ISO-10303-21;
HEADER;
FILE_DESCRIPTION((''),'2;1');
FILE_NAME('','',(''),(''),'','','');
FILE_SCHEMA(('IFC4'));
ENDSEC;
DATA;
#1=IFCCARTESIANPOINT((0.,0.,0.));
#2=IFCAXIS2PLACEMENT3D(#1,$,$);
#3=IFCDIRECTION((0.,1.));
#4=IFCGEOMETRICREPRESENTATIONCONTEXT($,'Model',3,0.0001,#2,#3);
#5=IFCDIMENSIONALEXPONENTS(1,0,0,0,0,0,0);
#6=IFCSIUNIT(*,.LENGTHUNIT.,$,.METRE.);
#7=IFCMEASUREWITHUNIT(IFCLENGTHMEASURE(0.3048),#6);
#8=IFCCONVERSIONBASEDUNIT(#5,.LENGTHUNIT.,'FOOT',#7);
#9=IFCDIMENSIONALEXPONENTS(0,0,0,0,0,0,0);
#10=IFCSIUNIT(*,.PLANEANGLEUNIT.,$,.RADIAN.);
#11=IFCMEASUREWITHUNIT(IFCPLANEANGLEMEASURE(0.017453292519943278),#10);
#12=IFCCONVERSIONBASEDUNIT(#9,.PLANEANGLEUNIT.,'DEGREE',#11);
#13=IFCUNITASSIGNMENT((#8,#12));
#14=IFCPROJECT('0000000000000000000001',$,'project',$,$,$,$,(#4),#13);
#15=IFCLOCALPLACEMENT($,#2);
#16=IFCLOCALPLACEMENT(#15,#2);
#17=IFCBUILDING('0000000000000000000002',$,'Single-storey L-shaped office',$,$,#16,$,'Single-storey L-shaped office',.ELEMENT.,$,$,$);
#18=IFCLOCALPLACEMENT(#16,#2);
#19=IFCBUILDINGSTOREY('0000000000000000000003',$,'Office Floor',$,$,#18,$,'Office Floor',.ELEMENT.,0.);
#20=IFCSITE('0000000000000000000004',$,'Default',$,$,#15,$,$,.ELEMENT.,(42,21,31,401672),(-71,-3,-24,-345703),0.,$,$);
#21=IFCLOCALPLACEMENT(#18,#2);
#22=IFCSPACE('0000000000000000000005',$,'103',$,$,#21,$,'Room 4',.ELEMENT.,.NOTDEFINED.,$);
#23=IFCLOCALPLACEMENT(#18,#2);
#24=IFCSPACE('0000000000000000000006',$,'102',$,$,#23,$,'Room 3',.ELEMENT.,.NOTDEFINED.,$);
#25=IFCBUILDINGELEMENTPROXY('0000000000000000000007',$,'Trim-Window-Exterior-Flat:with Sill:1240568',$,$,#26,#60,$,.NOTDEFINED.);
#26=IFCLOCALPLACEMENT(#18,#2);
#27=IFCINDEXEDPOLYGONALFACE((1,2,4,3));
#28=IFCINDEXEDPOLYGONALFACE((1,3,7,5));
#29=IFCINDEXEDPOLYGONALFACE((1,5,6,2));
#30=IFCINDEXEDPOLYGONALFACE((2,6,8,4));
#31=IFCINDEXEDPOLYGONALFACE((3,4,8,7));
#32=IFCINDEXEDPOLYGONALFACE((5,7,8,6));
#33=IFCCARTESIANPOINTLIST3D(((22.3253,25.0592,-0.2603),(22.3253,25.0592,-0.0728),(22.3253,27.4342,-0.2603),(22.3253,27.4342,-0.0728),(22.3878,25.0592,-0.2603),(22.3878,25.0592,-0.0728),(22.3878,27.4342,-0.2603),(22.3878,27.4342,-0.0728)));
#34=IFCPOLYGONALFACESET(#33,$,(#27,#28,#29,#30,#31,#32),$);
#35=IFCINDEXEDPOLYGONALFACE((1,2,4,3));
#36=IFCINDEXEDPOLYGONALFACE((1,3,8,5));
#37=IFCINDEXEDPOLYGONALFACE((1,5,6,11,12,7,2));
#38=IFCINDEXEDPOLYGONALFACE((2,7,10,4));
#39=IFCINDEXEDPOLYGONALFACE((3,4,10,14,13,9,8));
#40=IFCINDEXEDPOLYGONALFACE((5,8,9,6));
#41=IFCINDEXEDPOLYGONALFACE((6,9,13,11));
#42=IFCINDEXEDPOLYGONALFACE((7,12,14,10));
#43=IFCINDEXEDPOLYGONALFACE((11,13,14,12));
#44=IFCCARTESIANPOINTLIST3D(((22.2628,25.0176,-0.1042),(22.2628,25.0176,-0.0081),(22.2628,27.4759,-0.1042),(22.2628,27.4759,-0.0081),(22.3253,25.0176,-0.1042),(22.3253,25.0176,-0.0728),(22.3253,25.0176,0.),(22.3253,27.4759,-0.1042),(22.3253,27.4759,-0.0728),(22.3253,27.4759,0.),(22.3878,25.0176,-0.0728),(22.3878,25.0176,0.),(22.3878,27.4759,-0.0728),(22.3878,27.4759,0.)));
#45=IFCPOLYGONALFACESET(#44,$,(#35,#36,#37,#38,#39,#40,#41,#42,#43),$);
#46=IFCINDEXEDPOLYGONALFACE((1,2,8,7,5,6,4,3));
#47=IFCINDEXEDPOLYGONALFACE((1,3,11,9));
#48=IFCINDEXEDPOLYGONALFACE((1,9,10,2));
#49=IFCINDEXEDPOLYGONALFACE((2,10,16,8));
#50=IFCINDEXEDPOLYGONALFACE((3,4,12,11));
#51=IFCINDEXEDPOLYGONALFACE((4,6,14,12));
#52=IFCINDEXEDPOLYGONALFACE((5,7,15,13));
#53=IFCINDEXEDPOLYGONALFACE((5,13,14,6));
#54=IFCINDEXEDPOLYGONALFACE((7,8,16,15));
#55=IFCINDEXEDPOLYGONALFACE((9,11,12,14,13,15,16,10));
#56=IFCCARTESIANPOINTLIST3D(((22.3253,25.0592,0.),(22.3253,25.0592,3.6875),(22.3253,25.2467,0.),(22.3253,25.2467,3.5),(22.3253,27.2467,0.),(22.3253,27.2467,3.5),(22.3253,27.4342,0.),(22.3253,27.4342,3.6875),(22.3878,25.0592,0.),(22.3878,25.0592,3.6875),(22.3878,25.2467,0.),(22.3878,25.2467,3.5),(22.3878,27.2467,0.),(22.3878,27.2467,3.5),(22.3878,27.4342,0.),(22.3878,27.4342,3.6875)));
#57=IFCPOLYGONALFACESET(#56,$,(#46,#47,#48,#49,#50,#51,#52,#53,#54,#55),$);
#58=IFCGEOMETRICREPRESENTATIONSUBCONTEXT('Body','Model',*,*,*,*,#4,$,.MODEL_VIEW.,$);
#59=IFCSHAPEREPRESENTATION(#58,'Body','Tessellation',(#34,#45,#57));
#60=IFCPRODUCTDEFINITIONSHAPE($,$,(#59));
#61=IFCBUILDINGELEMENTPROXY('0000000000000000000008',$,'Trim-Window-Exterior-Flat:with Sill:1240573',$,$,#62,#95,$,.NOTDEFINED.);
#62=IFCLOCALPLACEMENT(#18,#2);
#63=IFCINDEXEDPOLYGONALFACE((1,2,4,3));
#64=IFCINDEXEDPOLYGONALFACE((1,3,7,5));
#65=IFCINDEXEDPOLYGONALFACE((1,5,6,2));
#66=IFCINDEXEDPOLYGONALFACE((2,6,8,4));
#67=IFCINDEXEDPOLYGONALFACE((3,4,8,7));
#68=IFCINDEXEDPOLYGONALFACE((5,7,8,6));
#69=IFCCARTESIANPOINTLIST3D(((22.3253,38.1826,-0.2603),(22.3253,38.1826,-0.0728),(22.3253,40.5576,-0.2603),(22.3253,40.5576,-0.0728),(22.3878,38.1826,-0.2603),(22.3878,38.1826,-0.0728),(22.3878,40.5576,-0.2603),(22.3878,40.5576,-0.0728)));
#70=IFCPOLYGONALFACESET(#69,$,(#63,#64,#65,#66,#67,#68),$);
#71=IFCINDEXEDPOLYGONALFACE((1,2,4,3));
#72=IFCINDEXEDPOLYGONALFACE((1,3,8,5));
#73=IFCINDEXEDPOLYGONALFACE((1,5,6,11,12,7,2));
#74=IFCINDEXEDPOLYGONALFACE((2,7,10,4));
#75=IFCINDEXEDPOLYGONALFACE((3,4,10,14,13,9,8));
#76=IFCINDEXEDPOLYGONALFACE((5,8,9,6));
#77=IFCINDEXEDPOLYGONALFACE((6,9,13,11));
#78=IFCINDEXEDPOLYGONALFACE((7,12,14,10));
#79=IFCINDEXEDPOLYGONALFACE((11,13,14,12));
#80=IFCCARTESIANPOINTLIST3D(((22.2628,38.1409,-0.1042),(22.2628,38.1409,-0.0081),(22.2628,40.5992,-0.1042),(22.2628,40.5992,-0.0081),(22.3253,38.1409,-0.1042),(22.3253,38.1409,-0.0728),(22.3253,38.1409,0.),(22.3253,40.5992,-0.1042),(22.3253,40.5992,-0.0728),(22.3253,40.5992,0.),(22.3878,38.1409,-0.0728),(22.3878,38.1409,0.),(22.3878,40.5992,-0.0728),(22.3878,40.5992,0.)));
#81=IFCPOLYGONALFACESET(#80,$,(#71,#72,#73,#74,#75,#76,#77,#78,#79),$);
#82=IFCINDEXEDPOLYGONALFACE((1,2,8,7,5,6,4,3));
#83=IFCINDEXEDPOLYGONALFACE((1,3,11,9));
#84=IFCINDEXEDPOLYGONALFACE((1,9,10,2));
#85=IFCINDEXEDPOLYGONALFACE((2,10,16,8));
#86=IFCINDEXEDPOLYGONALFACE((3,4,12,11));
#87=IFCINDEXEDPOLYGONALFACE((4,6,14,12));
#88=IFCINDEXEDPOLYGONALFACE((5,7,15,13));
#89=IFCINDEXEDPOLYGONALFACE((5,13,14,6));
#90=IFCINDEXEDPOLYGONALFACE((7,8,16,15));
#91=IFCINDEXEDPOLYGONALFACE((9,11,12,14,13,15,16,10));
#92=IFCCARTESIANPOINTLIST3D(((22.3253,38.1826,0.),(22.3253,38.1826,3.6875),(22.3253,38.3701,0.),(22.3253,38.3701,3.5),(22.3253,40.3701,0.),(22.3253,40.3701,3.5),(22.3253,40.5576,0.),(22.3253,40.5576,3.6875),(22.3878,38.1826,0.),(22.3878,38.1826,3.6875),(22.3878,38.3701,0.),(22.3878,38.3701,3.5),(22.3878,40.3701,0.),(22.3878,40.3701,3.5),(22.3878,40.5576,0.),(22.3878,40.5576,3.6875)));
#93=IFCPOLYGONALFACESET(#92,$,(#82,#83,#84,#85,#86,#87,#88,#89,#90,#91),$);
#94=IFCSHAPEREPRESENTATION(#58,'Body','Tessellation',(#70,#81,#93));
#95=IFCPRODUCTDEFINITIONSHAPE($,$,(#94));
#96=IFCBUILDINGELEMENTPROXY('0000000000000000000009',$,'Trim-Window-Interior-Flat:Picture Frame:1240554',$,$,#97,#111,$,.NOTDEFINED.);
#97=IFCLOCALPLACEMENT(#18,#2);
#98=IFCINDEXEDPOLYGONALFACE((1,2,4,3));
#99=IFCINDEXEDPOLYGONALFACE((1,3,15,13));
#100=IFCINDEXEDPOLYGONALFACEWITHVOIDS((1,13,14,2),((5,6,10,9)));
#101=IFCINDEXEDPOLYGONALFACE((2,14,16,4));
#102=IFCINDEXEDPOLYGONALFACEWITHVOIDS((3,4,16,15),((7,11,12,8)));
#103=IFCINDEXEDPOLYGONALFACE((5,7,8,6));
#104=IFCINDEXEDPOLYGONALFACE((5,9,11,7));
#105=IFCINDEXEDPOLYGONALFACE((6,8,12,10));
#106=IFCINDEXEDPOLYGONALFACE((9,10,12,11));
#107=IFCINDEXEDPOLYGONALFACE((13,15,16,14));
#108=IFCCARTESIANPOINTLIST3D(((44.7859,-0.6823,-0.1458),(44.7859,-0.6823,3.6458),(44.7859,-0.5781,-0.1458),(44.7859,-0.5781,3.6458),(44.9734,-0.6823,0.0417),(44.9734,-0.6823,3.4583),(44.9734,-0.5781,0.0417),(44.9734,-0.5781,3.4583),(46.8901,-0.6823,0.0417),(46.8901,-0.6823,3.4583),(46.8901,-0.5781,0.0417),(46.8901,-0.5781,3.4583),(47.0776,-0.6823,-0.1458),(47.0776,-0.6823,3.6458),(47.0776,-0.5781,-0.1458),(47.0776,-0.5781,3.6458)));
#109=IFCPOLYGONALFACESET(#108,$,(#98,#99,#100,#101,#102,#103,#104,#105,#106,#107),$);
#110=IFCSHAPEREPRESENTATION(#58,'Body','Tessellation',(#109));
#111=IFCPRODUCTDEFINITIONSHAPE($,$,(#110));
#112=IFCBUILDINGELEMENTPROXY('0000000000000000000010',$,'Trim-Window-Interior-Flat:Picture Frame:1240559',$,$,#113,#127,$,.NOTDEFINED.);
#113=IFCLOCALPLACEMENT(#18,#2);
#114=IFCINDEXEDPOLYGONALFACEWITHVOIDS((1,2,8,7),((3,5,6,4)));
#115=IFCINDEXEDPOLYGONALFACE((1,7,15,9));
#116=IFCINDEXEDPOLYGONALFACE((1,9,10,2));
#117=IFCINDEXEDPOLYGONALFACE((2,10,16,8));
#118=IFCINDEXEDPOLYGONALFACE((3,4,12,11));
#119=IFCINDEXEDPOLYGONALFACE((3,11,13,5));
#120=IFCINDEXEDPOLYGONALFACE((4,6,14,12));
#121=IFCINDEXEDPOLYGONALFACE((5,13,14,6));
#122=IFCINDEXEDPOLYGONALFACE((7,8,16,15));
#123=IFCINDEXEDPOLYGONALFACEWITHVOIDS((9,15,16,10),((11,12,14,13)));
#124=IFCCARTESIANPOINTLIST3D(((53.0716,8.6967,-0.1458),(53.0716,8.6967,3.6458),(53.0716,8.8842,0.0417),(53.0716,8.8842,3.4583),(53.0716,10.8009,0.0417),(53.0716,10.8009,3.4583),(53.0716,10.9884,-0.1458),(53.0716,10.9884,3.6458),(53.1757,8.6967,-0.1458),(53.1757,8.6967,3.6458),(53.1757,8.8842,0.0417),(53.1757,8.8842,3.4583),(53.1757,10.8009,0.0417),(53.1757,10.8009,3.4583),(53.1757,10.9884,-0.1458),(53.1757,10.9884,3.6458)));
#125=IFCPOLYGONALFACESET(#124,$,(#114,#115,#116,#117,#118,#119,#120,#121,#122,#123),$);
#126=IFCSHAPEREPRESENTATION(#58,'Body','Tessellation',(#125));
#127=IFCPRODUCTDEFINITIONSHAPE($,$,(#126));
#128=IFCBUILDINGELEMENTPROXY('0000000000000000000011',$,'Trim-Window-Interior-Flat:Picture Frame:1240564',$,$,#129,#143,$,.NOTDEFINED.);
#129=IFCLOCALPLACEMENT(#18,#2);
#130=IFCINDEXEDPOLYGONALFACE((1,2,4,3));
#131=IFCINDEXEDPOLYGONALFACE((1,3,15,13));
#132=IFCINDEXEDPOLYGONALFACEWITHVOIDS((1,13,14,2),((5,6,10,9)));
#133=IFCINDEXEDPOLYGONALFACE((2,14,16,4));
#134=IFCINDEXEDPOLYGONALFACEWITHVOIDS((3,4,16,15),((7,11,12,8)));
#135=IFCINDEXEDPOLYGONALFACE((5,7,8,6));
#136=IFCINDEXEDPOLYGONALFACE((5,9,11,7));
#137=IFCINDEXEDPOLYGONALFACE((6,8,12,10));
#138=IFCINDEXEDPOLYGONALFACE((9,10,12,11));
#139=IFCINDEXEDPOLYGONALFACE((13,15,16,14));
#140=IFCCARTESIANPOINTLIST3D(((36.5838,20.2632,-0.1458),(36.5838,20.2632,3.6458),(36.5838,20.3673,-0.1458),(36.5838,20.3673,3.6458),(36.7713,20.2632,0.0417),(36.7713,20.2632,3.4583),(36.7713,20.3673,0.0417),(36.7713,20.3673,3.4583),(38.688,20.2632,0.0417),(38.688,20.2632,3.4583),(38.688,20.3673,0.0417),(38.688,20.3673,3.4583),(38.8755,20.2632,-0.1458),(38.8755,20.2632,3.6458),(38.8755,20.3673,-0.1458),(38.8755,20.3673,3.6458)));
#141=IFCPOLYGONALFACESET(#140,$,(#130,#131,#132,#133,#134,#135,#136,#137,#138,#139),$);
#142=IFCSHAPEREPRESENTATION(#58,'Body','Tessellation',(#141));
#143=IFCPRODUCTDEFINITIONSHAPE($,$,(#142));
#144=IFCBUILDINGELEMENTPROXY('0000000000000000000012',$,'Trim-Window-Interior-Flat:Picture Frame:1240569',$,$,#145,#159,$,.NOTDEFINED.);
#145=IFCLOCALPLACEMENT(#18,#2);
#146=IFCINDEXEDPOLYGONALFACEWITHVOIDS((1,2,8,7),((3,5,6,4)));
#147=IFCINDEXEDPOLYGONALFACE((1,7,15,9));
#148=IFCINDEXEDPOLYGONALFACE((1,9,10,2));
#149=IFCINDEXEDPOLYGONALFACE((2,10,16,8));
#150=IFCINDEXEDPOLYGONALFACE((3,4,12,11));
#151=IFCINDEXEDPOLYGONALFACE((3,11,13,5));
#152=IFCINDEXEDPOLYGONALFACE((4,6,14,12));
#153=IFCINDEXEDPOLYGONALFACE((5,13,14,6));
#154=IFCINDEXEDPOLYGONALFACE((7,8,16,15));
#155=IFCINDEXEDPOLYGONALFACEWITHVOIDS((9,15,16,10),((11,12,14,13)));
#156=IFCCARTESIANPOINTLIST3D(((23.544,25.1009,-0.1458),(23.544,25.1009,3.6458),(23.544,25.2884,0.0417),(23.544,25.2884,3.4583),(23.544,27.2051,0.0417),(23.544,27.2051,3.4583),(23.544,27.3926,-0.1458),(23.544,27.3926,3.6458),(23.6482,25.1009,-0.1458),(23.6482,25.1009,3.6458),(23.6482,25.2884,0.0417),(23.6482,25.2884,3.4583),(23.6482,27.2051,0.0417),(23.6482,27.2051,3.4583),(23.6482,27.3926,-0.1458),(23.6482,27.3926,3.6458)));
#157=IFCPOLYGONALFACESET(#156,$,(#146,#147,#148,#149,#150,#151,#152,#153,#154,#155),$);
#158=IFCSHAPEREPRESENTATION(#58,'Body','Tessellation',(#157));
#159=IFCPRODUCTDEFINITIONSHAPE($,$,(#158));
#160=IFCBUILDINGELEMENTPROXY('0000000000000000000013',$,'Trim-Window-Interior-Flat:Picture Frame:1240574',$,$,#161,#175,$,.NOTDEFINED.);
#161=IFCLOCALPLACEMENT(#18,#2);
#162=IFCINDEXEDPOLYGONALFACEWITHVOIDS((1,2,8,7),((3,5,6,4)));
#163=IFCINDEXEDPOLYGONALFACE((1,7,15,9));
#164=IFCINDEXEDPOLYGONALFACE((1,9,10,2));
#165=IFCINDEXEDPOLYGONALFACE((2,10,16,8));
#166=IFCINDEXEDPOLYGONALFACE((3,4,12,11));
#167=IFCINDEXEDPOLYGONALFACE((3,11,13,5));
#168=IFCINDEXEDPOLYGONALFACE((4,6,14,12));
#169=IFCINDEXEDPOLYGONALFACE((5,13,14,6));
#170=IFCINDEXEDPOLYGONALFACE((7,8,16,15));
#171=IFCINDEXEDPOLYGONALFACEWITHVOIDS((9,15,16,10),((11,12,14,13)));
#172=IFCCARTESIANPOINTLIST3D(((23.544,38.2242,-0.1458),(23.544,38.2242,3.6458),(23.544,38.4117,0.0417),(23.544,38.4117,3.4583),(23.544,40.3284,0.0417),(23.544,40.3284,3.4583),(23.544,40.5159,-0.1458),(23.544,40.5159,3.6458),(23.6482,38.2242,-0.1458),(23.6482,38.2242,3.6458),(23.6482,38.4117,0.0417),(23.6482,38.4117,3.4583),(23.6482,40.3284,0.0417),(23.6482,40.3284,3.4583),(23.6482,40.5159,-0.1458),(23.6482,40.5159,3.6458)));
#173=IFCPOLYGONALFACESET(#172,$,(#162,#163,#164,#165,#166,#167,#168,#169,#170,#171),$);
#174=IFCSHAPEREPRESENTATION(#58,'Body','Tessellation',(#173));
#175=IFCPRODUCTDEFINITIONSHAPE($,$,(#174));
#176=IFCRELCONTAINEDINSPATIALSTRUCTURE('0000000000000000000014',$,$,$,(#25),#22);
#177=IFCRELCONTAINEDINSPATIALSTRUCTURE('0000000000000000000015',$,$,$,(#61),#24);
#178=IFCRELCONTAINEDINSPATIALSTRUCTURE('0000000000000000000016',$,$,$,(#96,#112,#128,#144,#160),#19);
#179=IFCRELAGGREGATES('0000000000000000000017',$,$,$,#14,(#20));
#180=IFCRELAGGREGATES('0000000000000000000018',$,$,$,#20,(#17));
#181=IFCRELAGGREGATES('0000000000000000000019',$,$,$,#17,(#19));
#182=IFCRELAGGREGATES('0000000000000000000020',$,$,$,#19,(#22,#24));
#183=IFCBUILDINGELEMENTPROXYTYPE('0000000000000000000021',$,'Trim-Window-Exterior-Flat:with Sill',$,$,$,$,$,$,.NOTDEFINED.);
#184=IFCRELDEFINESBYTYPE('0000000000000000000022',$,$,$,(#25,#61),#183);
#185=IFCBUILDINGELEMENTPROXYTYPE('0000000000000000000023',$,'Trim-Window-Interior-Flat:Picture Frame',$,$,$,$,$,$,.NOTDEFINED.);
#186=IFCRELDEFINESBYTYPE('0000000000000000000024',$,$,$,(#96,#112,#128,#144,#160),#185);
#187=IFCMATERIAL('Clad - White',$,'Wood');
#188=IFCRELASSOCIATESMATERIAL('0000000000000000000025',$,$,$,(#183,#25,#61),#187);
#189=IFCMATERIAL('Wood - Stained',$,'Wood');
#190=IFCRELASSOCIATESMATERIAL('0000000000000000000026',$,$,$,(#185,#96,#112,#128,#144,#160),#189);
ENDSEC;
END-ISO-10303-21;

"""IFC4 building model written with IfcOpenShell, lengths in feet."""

from ifc_helpers import new_model, entity, si_unit, converted_unit, direction, frame, origin, place, context, subcontext, project, spatial, indexed_curve, outline, extrude, source, transform, mapped, material, type_object, type_shapes, element, save


model = new_model("IFC4")

# Units and contexts
model_context = context("Model", 3, precision=0.0001, world=origin(), true_north=direction((0.0, 1.0)))
body_context = subcontext(model_context, "Body", "Model", "MODEL_VIEW")
ifc_project = project(units=[converted_unit("LENGTHUNIT", "FOOT", entity("IfcLengthMeasure", 0.3048), si_unit("LENGTHUNIT", "METRE"), dimensions=[1, 0, 0, 0, 0, 0, 0]), converted_unit("PLANEANGLEUNIT", "DEGREE", entity("IfcPlaneAngleMeasure", 0.017453292519943278), si_unit("PLANEANGLEUNIT", "RADIAN"), dimensions=[0, 0, 0, 0, 0, 0, 0])], contexts=[model_context])

# Site, building, storey
site_placement = place(None, origin())
site = spatial("IfcSite", under=ifc_project, at=site_placement, Name="Default", CompositionType="ELEMENT", RefLatitude=(42, 21, 31, 401672), RefLongitude=(-71, -3, -24, -345703), RefElevation=0.0)
building_placement = place(site_placement, origin())
building = spatial("IfcBuilding", under=site, at=building_placement, Name="Single-storey L-shaped office", LongName="Single-storey L-shaped office", CompositionType="ELEMENT")
storey_placement = place(building_placement, origin())
storey = spatial("IfcBuildingStorey", under=building, at=storey_placement, Name="Office Floor", LongName="Office Floor", CompositionType="ELEMENT", Elevation=0.0)

# Shared definitions
ifc_material_1 = material(Name="Wood - Stained", Category="Wood")

# Shared definitions
ifc_material_2 = material(Name="Clad - White", Category="Wood")

# Shared definitions
building_element_proxy_type_1 = type_object("IfcBuildingElementProxyType", Name="Trim-Window-Exterior-Flat:with Sill", PredefinedType="NOTDEFINED", material=ifc_material_2)
shared_shape_1 = source(origin(), body_context, "Body", "SweptSolid", [
    extrude(outline(indexed_curve([(-1.1875, -0.0938), (1.1875, -0.0938), (1.1875, 0.0938), (-1.1875, 0.0938), (-1.1875, -0.0938)], self_intersect=False)), frame((0.0, -3.6665, 0.0), z_axis=(0.0, 0.0, 1.0), x_axis=(-1.0, 0.0, 0.0)), (0.0, 0.0, 1.0), 0.0625),
    extrude(outline(indexed_curve([(-0.0625, -0.0525), (0.0, -0.0525), (0.0, -0.0211), (0.0625, -0.0211), (0.0625, 0.0517), (0.0, 0.0517), (-0.0625, 0.0436), (-0.0625, -0.0525)], self_intersect=False)), frame((-1.2292, -3.5517, 0.0625), z_axis=(1.0, 0.0, 0.0), x_axis=(0.0, 0.0, -1.0)), (0.0, 0.0, 1.0), 2.4583),
    extrude(outline(indexed_curve([(-1.8906, -1.1875), (1.7969, -1.1875), (1.7969, -1.0), (-1.7031, -1.0), (-1.7031, 1.0), (1.7969, 1.0), (1.7969, 1.1875), (-1.8906, 1.1875), (-1.8906, -1.1875)], self_intersect=False)), frame((0.0, -1.7031, 0.0), z_axis=(0.0, 0.0, 1.0), x_axis=(0.0, -1.0, 0.0)), (0.0, 0.0, 1.0), 0.0625),
])
type_shapes(building_element_proxy_type_1, [shared_shape_1])

# Shared definitions
space_1_placement = place(storey_placement, origin())
space_1 = spatial("IfcSpace", under=storey, at=space_1_placement, Name="103", LongName="Room 4", CompositionType="ELEMENT", PredefinedType="NOTDEFINED")

# Building element proxy
proxy_1_placement = place(space_1_placement, frame((22.3878, 26.2467, 3.5), z_axis=(-1.0, 0.0, 0.0), x_axis=(0.0, -1.0, 0.0)))
element("IfcBuildingElementProxy", 1, at=proxy_1_placement, inside=space_1, type_object=building_element_proxy_type_1, material=ifc_material_2, Name="Trim-Window-Exterior-Flat:with Sill:1240568", PredefinedType="NOTDEFINED", context=body_context, shape_type="MappedRepresentation", body=[
    mapped(shared_shape_1, transform((0.0, 0.0, 0.0), scale=1.0)),
])

# Shared definitions
space_2_placement = place(storey_placement, origin())
space_2 = spatial("IfcSpace", under=storey, at=space_2_placement, Name="102", LongName="Room 3", CompositionType="ELEMENT", PredefinedType="NOTDEFINED")

# Building element proxies
proxy_2_placement = place(space_2_placement, frame((22.3878, 39.3701, 3.5), z_axis=(-1.0, 0.0, 0.0), x_axis=(0.0, -1.0, 0.0)))
element("IfcBuildingElementProxy", 2, at=proxy_2_placement, inside=space_2, type_object=building_element_proxy_type_1, material=ifc_material_2, Name="Trim-Window-Exterior-Flat:with Sill:1240573", PredefinedType="NOTDEFINED", context=body_context, shape_type="MappedRepresentation", body=[
    mapped(shared_shape_1, transform((0.0, 0.0, 0.0), scale=1.0)),
])
building_element_proxy_type_2 = type_object("IfcBuildingElementProxyType", Name="Trim-Window-Interior-Flat:Picture Frame", PredefinedType="NOTDEFINED", material=ifc_material_1)
shared_shape_2 = source(origin(), body_context, "Body", "SweptSolid", [
    extrude(outline(indexed_curve([(-1.1458, -1.8958), (1.1458, -1.8958), (1.1458, 1.8958), (-1.1458, 1.8958), (-1.1458, -1.8958)], self_intersect=False), holes=[indexed_curve([(-0.9583, -1.7083), (-0.9583, 1.7083), (0.9583, 1.7083), (0.9583, -1.7083), (-0.9583, -1.7083)], self_intersect=False)]), frame((0.0, -1.75, 0.0), z_axis=(0.0, 0.0, 1.0), x_axis=(-1.0, 0.0, 0.0)), (0.0, 0.0, 1.0), 0.1042),
])
type_shapes(building_element_proxy_type_2, [shared_shape_2])
for number, where, z_axis, x_axis, name in (
    (3, (45.9318, -0.5781, 3.5), (0.0, -1.0, 0.0), (1.0, 0.0, 0.0), "Trim-Window-Interior-Flat:Picture Frame:1240554"),
    (4, (53.0716, 9.8425, 3.5), (1.0, 0.0, 0.0), (0.0, 1.0, 0.0), "Trim-Window-Interior-Flat:Picture Frame:1240559"),
    (5, (37.7297, 20.2632, 3.5), (0.0, 1.0, 0.0), (-1.0, 0.0, 0.0), "Trim-Window-Interior-Flat:Picture Frame:1240564"),
    (6, (23.544, 26.2467, 3.5), (1.0, 0.0, 0.0), (0.0, 1.0, 0.0), "Trim-Window-Interior-Flat:Picture Frame:1240569"),
    (7, (23.544, 39.3701, 3.5), (1.0, 0.0, 0.0), (0.0, 1.0, 0.0), "Trim-Window-Interior-Flat:Picture Frame:1240574"),
):
    element("IfcBuildingElementProxy", number, at=place(storey_placement, frame(where, z_axis=z_axis, x_axis=x_axis)), inside=storey, type_object=building_element_proxy_type_2, material=ifc_material_1, Name=name, PredefinedType="NOTDEFINED", context=body_context, shape_type="MappedRepresentation", body=[
        mapped(shared_shape_2, transform((0.0, 0.0, 0.0), scale=1.0)),
    ])

save(model, "model.ifc")
